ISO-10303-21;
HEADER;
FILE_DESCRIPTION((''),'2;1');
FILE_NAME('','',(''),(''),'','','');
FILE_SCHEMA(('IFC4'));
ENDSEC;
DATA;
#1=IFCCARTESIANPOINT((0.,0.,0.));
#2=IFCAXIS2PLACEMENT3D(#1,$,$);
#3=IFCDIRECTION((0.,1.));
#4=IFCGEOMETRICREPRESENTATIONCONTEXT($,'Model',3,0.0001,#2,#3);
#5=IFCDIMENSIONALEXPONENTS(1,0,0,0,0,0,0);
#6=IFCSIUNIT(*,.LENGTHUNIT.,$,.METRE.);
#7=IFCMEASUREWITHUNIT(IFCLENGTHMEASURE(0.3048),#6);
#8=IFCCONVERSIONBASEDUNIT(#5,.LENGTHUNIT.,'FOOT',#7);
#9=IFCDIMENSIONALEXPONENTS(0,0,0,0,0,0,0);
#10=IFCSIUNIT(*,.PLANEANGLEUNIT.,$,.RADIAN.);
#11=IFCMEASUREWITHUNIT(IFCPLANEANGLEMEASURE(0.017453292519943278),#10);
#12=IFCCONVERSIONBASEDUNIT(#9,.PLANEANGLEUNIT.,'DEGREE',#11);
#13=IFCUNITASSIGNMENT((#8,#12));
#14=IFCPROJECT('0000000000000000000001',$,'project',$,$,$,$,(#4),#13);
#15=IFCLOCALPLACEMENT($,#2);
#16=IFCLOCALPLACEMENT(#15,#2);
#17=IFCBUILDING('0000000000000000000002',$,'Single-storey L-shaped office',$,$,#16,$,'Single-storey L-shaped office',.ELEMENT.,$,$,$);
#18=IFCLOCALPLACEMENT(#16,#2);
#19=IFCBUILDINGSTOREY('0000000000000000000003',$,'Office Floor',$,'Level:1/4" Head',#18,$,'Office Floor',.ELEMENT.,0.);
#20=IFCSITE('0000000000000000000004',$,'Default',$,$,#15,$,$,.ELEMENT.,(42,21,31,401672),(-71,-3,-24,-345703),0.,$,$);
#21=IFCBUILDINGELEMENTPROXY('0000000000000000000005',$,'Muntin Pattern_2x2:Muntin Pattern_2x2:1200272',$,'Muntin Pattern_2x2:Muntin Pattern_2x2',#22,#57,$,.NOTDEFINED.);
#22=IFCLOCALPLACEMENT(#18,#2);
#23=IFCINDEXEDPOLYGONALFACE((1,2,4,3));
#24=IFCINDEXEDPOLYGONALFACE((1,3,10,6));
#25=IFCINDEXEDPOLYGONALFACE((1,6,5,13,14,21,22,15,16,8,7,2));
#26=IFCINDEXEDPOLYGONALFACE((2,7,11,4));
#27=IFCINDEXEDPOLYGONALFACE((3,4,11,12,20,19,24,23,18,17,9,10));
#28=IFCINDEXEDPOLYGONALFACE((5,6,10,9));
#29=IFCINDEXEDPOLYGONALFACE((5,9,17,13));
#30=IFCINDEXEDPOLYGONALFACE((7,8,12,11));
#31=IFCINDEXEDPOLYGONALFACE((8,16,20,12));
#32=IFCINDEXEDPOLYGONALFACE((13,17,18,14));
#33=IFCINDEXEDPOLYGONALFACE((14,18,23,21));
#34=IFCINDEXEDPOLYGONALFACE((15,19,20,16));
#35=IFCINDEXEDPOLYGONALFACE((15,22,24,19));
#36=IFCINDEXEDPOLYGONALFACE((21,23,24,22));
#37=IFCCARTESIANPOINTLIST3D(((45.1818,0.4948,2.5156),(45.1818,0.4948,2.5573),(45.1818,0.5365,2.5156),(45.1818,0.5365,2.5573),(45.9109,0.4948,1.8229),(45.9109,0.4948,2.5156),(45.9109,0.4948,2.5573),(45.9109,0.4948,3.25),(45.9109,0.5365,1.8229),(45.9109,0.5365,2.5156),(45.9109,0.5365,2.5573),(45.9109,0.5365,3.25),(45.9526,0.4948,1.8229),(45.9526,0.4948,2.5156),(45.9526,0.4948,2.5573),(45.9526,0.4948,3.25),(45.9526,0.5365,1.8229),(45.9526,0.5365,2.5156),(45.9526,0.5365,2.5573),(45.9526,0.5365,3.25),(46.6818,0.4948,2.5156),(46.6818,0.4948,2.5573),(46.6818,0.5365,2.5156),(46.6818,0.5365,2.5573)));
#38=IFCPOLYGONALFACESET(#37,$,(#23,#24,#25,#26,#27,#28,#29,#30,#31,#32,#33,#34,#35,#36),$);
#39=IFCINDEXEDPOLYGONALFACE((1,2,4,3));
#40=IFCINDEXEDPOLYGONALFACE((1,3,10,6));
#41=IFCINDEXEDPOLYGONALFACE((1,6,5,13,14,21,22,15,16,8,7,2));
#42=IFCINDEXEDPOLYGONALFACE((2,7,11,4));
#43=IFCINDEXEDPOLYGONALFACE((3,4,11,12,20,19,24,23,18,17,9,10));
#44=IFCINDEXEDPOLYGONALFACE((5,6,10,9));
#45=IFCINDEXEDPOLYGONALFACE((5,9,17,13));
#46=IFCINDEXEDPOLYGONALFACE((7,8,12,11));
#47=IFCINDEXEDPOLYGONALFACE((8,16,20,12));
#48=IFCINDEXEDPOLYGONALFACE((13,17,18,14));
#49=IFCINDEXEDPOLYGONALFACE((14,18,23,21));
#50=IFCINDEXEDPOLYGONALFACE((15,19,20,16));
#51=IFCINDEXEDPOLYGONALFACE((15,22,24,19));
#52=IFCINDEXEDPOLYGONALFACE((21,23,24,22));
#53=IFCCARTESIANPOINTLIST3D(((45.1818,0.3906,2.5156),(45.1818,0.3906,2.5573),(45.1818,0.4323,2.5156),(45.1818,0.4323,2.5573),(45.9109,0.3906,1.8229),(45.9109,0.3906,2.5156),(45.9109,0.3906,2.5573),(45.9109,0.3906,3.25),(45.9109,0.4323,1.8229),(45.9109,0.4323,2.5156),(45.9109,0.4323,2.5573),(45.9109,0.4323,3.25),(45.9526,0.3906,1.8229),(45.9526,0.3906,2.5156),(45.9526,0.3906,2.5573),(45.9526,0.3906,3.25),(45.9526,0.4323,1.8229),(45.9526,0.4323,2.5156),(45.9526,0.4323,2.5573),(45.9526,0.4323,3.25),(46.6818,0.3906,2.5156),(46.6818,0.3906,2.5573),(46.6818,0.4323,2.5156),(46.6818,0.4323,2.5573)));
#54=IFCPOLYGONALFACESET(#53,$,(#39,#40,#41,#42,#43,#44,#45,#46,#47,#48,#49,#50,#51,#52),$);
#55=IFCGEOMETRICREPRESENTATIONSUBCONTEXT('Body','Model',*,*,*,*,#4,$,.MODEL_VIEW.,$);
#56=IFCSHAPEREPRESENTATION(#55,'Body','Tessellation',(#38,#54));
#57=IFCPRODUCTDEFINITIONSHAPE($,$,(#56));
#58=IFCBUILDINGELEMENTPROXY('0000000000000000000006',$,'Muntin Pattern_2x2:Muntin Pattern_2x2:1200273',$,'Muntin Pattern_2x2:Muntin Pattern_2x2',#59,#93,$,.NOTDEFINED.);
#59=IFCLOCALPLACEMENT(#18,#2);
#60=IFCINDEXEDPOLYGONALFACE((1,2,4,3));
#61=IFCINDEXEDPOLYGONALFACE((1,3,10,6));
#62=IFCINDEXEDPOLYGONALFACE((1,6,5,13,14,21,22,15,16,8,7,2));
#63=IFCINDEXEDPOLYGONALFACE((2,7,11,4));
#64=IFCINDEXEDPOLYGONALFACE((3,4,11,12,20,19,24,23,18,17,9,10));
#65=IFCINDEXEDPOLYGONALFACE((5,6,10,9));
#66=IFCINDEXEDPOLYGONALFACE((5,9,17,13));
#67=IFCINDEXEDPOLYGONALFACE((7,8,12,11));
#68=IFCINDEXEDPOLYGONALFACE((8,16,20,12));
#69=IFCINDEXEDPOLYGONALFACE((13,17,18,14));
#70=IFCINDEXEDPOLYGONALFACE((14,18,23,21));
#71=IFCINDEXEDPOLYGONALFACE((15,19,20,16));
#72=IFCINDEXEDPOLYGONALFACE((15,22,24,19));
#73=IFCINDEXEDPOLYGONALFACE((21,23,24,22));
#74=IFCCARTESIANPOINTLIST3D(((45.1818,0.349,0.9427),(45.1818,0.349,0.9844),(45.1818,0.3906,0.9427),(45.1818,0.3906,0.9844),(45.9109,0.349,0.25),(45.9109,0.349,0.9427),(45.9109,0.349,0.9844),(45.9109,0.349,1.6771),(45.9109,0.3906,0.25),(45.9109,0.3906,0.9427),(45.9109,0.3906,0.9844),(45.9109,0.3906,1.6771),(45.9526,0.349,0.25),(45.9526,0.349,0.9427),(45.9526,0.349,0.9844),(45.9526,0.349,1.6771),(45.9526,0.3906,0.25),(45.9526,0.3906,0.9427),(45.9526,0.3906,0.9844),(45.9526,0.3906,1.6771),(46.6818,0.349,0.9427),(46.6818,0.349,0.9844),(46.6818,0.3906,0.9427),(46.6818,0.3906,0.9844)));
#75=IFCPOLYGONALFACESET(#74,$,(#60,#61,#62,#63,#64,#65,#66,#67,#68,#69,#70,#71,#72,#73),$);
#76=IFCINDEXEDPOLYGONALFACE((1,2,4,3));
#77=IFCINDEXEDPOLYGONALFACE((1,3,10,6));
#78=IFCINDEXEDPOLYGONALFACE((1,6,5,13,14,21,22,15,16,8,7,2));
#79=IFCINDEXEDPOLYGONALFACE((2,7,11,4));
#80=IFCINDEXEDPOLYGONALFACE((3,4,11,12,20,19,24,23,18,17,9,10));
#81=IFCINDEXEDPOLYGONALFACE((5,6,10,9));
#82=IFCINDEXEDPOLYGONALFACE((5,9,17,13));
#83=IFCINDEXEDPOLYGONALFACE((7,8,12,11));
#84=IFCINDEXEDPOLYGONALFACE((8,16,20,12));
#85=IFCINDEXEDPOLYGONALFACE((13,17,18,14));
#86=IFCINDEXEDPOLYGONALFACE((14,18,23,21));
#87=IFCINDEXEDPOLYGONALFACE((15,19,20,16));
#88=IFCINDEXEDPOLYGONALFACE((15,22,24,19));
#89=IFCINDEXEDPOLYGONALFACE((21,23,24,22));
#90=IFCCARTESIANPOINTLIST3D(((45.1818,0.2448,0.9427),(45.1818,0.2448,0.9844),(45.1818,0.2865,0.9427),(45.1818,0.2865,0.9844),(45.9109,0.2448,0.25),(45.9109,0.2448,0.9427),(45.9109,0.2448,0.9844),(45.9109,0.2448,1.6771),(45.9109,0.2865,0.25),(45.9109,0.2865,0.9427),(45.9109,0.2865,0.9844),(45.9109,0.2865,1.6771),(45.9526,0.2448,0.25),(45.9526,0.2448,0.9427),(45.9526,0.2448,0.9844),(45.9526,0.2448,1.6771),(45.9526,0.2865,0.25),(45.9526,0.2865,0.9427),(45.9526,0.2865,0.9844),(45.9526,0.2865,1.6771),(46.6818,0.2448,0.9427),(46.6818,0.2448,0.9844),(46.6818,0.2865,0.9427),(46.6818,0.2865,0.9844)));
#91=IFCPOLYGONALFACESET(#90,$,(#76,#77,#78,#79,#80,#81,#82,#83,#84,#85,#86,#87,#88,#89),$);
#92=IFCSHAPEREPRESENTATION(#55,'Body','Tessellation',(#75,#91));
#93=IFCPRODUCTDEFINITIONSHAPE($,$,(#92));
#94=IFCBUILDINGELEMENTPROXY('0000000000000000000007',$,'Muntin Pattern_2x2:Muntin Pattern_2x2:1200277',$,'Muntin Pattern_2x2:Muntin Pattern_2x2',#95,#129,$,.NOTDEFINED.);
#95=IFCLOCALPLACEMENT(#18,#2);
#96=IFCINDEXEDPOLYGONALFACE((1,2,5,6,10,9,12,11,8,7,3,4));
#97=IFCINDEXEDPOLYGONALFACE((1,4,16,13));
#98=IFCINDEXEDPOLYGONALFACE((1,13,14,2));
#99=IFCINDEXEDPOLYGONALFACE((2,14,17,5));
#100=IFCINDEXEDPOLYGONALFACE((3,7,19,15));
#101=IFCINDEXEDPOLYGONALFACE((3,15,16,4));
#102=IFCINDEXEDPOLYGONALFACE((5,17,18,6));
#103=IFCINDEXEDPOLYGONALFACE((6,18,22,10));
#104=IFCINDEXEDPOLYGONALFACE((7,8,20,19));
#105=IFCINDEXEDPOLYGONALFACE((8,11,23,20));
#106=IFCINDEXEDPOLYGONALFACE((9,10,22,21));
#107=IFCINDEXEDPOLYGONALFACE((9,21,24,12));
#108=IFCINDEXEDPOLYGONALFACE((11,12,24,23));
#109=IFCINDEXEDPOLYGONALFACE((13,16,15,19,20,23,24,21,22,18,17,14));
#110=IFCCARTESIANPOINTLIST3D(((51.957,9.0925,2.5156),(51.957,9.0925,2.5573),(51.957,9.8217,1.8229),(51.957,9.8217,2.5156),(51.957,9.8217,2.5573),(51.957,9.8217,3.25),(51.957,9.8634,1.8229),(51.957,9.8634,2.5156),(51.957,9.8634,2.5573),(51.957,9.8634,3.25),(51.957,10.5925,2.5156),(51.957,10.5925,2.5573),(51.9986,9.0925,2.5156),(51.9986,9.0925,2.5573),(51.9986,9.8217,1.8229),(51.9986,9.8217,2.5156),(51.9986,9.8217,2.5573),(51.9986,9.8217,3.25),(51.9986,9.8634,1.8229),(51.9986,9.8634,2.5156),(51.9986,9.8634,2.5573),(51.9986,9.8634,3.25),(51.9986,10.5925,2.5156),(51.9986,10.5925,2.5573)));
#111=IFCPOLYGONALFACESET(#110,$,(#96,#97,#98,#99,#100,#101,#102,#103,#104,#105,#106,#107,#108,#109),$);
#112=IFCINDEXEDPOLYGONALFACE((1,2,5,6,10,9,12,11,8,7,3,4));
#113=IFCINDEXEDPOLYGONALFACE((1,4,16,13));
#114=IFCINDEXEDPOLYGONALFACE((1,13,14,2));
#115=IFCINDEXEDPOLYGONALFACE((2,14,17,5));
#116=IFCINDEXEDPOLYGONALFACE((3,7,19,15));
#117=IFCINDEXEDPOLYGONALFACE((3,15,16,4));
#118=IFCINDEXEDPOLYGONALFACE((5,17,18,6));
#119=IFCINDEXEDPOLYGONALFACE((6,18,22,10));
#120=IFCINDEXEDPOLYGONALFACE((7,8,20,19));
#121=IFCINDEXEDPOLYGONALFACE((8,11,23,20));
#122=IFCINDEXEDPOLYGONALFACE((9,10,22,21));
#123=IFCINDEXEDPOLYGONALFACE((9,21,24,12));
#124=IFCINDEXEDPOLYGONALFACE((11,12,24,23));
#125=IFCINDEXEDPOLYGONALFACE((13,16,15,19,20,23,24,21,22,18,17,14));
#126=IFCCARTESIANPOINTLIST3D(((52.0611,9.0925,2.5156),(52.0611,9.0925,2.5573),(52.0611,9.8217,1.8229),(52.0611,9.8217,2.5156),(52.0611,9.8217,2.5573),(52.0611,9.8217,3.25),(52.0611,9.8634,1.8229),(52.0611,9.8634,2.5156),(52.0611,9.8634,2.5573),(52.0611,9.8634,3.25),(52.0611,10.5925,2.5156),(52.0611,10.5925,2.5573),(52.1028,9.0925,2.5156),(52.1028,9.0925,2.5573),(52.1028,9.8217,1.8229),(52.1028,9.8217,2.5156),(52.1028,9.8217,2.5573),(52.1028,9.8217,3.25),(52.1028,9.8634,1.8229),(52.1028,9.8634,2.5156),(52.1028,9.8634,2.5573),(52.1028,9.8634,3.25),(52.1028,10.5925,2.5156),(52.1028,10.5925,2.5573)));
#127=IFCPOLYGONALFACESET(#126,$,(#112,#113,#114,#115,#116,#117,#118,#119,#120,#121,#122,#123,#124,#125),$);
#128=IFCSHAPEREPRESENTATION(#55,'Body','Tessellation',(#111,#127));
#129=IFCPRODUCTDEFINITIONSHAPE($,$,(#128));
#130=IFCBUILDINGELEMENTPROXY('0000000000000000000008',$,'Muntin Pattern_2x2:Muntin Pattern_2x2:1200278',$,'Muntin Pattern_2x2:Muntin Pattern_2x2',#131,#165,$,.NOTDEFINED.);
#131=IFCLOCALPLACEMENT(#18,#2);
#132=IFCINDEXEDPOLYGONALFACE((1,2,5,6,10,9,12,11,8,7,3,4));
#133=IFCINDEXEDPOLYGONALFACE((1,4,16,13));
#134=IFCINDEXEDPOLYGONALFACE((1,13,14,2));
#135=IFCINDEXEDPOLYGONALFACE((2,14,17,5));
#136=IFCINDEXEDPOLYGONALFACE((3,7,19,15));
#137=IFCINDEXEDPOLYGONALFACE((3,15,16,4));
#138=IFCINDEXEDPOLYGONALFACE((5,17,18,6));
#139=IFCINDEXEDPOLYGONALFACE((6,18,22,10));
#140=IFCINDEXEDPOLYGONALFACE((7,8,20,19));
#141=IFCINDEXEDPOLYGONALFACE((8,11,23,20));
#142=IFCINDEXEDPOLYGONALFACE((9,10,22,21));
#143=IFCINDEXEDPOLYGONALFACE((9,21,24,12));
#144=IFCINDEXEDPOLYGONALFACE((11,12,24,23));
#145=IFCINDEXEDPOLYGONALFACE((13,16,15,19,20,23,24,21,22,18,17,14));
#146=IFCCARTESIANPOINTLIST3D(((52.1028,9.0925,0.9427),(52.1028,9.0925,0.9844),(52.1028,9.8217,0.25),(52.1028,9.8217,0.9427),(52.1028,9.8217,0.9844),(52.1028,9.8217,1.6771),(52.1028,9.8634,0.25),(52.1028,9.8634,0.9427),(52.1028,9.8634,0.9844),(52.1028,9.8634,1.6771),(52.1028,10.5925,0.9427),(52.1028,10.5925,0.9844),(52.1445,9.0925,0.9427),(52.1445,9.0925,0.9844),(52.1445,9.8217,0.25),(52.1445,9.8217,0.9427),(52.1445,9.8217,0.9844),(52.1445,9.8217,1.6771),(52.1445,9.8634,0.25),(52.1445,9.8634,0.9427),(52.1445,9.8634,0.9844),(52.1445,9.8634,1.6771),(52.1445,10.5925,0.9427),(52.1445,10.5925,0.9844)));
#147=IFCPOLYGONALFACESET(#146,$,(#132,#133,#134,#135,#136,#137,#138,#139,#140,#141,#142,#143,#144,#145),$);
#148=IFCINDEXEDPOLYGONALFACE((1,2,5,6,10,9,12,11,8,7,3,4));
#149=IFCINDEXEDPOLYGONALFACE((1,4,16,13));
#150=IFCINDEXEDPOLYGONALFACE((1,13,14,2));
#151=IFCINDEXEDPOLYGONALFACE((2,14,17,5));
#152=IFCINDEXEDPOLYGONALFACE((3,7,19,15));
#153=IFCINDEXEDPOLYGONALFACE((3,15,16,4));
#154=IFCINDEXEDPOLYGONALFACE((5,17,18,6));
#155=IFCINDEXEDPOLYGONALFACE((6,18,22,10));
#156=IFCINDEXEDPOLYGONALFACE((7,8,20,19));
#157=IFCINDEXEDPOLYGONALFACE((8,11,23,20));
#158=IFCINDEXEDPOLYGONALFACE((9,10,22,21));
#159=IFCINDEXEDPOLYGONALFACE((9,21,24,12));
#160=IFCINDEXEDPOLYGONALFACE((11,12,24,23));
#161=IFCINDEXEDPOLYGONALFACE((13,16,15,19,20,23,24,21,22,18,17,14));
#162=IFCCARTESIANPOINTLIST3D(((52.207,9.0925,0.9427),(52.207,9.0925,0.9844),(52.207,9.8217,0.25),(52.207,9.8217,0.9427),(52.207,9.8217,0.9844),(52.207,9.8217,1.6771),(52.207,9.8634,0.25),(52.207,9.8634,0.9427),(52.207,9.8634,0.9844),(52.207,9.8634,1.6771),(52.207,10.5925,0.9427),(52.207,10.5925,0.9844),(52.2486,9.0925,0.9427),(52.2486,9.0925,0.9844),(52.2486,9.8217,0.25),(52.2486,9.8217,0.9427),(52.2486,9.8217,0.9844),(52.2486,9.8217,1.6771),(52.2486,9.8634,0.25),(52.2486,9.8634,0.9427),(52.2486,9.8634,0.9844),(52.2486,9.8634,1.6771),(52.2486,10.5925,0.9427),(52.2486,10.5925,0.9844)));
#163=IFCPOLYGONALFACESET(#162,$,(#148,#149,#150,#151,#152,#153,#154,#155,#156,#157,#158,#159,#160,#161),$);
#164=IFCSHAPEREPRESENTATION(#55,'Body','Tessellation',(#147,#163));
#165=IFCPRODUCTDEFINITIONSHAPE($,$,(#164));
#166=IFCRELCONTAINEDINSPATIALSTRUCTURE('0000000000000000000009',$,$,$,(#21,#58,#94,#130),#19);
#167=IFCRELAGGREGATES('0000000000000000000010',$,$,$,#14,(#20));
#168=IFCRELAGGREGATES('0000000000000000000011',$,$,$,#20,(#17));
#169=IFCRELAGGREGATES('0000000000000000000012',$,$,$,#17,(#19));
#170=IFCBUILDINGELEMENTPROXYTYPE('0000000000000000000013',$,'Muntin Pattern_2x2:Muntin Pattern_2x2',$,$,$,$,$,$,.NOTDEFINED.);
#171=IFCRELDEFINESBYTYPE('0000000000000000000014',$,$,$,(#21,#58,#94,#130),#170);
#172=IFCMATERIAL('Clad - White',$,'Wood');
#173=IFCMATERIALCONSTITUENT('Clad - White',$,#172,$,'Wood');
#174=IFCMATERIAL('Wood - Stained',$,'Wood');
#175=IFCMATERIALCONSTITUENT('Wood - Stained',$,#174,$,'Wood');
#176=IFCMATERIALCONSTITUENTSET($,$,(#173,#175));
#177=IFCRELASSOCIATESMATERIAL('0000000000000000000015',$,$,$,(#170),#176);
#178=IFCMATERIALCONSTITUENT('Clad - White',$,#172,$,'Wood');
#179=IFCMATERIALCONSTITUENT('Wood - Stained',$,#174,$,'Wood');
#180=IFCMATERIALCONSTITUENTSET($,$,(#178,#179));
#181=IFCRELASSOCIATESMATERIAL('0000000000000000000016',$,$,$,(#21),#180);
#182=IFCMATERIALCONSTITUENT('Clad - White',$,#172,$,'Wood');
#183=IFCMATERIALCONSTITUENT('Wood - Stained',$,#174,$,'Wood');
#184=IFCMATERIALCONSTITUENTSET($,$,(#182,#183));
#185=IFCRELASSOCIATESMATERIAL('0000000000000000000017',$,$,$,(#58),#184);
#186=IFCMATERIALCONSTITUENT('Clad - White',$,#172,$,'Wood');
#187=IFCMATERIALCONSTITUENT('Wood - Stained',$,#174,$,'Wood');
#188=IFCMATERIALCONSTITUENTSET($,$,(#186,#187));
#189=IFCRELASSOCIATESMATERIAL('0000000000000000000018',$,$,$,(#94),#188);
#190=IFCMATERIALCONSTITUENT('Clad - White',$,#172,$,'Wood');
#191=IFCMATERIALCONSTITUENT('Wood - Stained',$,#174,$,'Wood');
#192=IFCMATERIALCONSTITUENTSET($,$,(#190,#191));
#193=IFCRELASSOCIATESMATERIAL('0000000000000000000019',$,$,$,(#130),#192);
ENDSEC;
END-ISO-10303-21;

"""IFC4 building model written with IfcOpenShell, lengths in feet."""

from ifc_helpers import new_model, entity, si_unit, converted_unit, direction, frame, origin, place, context, subcontext, project, spatial, indexed_curve, outline, extrude, source, transform, mapped, material, constituent, constituent_set, type_object, type_shapes, element, save


model = new_model("IFC4")

# Units and contexts
model_context = context("Model", 3, precision=0.0001, world=origin(), true_north=direction((0.0, 1.0)))
body_context = subcontext(model_context, "Body", "Model", "MODEL_VIEW")
ifc_project = project(units=[converted_unit("LENGTHUNIT", "FOOT", entity("IfcLengthMeasure", 0.3048), si_unit("LENGTHUNIT", "METRE"), dimensions=[1, 0, 0, 0, 0, 0, 0]), converted_unit("PLANEANGLEUNIT", "DEGREE", entity("IfcPlaneAngleMeasure", 0.017453292519943278), si_unit("PLANEANGLEUNIT", "RADIAN"), dimensions=[0, 0, 0, 0, 0, 0, 0])], contexts=[model_context])

# Site, building, storey
site_placement = place(None, origin())
site = spatial("IfcSite", under=ifc_project, at=site_placement, Name="Default", CompositionType="ELEMENT", RefLatitude=(42, 21, 31, 401672), RefLongitude=(-71, -3, -24, -345703), RefElevation=0.0)
building_placement = place(site_placement, origin())
building = spatial("IfcBuilding", under=site, at=building_placement, Name="Single-storey L-shaped office", LongName="Single-storey L-shaped office", CompositionType="ELEMENT")
storey_placement = place(building_placement, origin())
storey = spatial("IfcBuildingStorey", under=building, at=storey_placement, Name="Office Floor", ObjectType="Level:1/4\" Head", LongName="Office Floor", CompositionType="ELEMENT", Elevation=0.0)

# Shared definitions
ifc_material_1 = material(Name="Wood - Stained", Category="Wood")

# Building element proxies
ifc_material_2 = material(Name="Clad - White", Category="Wood")
ifc_constituent_1 = constituent(ifc_material_2, Name="Clad - White", Category="Wood")
ifc_constituent_2 = constituent(ifc_material_1, Name="Wood - Stained", Category="Wood")
ifc_constituent_set_1 = constituent_set(constituents=[ifc_constituent_1, ifc_constituent_2])
ifc_constituent_3 = constituent(ifc_material_2, Name="Clad - White", Category="Wood")
ifc_constituent_4 = constituent(ifc_material_1, Name="Wood - Stained", Category="Wood")
ifc_constituent_set_2 = constituent_set(constituents=[ifc_constituent_3, ifc_constituent_4])
building_element_proxy_type_1 = type_object("IfcBuildingElementProxyType", Name="Muntin Pattern_2x2:Muntin Pattern_2x2", PredefinedType="NOTDEFINED", material=ifc_constituent_set_2)
shared_shape_1 = source(origin(), body_context, "Body", "SweptSolid", [
    extrude(outline(indexed_curve([(0.0208, -0.0208), (0.7135, -0.0208), (0.7135, 0.0208), (0.0208, 0.0208), (0.0208, 0.75), (-0.0208, 0.75), (-0.0208, 0.0208), (-0.7135, 0.0208), (-0.7135, -0.0208), (-0.0208, -0.0208), (-0.0208, -0.75), (0.0208, -0.75), (0.0208, -0.0208)], self_intersect=False)), frame((0.0, 0.0312, 0.7135), z_axis=(0.0, 1.0, 0.0), x_axis=(0.0, 0.0, 1.0)), (0.0, 0.0, 1.0), 0.0417),
    extrude(outline(indexed_curve([(0.0208, -0.0208), (0.7135, -0.0208), (0.7135, 0.0208), (0.0208, 0.0208), (0.0208, 0.75), (-0.0208, 0.75), (-0.0208, 0.0208), (-0.7135, 0.0208), (-0.7135, -0.0208), (-0.0208, -0.0208), (-0.0208, -0.75), (0.0208, -0.75), (0.0208, -0.0208)], self_intersect=False)), frame((0.0, -0.0729, 0.7135), z_axis=(0.0, 1.0, 0.0), x_axis=(0.0, 0.0, 1.0)), (0.0, 0.0, 1.0), 0.0417),
])
type_shapes(building_element_proxy_type_1, [shared_shape_1])
proxy_1_placement = place(storey_placement, frame((45.9318, 0.4635, 1.8229)))
element("IfcBuildingElementProxy", 1, at=proxy_1_placement, inside=storey, type_object=building_element_proxy_type_1, material=ifc_constituent_set_1, Name="Muntin Pattern_2x2:Muntin Pattern_2x2:1200272", ObjectType="Muntin Pattern_2x2:Muntin Pattern_2x2", PredefinedType="NOTDEFINED", context=body_context, shape_type="MappedRepresentation", body=[
    mapped(shared_shape_1, transform((0.0, 0.0, 0.0), scale=1.0)),
])
ifc_constituent_5 = constituent(ifc_material_2, Name="Clad - White", Category="Wood")
ifc_constituent_6 = constituent(ifc_material_1, Name="Wood - Stained", Category="Wood")
ifc_constituent_set_3 = constituent_set(constituents=[ifc_constituent_5, ifc_constituent_6])
proxy_2_placement = place(storey_placement, frame((45.9318, 0.3177, 0.25)))
element("IfcBuildingElementProxy", 2, at=proxy_2_placement, inside=storey, type_object=building_element_proxy_type_1, material=ifc_constituent_set_3, Name="Muntin Pattern_2x2:Muntin Pattern_2x2:1200273", ObjectType="Muntin Pattern_2x2:Muntin Pattern_2x2", PredefinedType="NOTDEFINED", context=body_context, shape_type="MappedRepresentation", body=[
    mapped(shared_shape_1, transform((0.0, 0.0, 0.0), scale=1.0)),
])
ifc_constituent_7 = constituent(ifc_material_2, Name="Clad - White", Category="Wood")
ifc_constituent_8 = constituent(ifc_material_1, Name="Wood - Stained", Category="Wood")
ifc_constituent_set_4 = constituent_set(constituents=[ifc_constituent_7, ifc_constituent_8])
proxy_3_placement = place(storey_placement, frame((52.0299, 9.8425, 1.8229), z_axis=(0.0, 0.0, 1.0), x_axis=(0.0, 1.0, 0.0)))
element("IfcBuildingElementProxy", 3, at=proxy_3_placement, inside=storey, type_object=building_element_proxy_type_1, material=ifc_constituent_set_4, Name="Muntin Pattern_2x2:Muntin Pattern_2x2:1200277", ObjectType="Muntin Pattern_2x2:Muntin Pattern_2x2", PredefinedType="NOTDEFINED", context=body_context, shape_type="MappedRepresentation", body=[
    mapped(shared_shape_1, transform((0.0, 0.0, 0.0), scale=1.0)),
])
ifc_constituent_9 = constituent(ifc_material_2, Name="Clad - White", Category="Wood")
ifc_constituent_10 = constituent(ifc_material_1, Name="Wood - Stained", Category="Wood")
ifc_constituent_set_5 = constituent_set(constituents=[ifc_constituent_9, ifc_constituent_10])
proxy_4_placement = place(storey_placement, frame((52.1757, 9.8425, 0.25), z_axis=(0.0, 0.0, 1.0), x_axis=(0.0, 1.0, 0.0)))
element("IfcBuildingElementProxy", 4, at=proxy_4_placement, inside=storey, type_object=building_element_proxy_type_1, material=ifc_constituent_set_5, Name="Muntin Pattern_2x2:Muntin Pattern_2x2:1200278", ObjectType="Muntin Pattern_2x2:Muntin Pattern_2x2", PredefinedType="NOTDEFINED", context=body_context, shape_type="MappedRepresentation", body=[
    mapped(shared_shape_1, transform((0.0, 0.0, 0.0), scale=1.0)),
])

save(model, "model.ifc")
